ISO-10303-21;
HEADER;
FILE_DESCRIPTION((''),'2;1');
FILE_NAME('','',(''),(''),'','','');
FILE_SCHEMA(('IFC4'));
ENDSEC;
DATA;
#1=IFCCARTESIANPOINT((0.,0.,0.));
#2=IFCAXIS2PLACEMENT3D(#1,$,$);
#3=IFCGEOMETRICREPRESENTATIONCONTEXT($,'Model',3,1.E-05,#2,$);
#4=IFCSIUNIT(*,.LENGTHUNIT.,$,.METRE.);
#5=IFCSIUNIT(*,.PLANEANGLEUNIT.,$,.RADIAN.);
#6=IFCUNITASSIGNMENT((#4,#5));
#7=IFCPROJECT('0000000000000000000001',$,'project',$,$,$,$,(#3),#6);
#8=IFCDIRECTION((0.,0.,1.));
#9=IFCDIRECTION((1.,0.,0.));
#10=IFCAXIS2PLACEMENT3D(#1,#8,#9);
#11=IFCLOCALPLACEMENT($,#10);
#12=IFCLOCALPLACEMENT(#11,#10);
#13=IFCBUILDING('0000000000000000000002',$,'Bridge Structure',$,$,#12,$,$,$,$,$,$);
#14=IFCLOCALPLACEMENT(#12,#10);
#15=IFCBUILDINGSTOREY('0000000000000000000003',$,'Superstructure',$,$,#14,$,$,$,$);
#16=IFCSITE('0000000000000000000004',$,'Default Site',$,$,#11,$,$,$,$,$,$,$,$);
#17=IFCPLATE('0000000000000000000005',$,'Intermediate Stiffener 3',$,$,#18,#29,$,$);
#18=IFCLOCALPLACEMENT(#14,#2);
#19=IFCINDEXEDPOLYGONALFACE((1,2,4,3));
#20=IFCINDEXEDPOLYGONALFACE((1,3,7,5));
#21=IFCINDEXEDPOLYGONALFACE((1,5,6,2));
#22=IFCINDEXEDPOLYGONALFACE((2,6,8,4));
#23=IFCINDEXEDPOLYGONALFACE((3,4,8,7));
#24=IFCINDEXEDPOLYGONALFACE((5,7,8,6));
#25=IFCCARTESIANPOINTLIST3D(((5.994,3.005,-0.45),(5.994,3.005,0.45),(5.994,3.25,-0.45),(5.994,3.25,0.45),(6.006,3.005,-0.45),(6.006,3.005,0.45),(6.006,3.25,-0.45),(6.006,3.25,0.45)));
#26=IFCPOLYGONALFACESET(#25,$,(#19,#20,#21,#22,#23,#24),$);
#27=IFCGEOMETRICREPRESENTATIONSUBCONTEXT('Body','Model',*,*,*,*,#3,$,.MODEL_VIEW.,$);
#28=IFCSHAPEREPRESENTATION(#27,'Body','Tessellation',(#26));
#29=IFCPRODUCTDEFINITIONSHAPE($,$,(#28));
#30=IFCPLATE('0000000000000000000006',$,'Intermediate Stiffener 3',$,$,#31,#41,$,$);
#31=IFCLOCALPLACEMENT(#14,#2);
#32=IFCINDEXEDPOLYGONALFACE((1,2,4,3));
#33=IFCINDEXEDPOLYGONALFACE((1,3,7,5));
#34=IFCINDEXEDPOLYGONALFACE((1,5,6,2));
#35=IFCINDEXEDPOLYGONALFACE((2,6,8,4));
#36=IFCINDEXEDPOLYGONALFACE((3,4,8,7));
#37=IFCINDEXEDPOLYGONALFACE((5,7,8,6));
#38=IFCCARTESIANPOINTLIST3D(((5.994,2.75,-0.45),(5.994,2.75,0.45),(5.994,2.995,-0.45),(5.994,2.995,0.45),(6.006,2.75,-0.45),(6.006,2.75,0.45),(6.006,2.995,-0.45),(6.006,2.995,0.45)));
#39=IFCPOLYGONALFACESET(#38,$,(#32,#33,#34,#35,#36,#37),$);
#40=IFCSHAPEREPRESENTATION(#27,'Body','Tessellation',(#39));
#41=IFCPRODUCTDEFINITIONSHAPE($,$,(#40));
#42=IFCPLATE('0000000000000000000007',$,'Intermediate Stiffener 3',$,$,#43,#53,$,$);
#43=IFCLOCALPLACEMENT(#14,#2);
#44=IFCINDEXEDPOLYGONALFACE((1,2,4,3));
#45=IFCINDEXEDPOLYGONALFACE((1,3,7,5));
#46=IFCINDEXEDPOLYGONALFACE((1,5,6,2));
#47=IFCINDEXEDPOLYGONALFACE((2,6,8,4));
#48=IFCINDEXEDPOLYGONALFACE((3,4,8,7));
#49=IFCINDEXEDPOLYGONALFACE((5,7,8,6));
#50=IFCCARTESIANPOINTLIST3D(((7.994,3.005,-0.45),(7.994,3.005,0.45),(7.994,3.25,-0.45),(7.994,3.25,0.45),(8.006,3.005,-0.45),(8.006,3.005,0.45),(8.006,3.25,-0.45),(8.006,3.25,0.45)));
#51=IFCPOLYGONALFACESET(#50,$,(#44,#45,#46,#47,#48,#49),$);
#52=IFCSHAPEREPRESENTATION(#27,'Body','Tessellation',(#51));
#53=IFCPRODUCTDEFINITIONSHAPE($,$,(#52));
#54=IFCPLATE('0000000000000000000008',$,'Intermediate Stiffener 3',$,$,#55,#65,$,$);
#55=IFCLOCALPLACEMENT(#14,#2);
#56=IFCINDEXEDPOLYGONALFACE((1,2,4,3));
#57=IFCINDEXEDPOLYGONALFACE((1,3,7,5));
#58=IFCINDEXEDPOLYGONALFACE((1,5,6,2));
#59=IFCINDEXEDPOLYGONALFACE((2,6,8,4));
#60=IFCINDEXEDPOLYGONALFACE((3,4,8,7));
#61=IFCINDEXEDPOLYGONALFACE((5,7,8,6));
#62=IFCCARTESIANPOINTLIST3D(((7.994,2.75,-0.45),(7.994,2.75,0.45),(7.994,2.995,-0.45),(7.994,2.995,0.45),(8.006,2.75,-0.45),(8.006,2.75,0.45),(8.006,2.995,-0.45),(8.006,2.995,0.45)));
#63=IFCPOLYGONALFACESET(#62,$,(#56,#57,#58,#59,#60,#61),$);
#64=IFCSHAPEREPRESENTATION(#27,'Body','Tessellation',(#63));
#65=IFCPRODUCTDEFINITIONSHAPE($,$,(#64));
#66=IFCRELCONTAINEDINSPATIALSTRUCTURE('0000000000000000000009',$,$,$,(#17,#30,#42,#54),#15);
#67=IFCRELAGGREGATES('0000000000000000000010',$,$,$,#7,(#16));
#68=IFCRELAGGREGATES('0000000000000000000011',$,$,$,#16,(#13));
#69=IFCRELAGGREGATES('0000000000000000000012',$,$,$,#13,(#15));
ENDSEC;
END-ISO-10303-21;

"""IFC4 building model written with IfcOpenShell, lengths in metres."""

from ifc_helpers import new_model, si_unit, frame, origin, origin_with_axes, origin_2d_with_axis, place, context, subcontext, project, spatial, rectangle, extrude, element, save


model = new_model("IFC4")

# Units and contexts
model_context = context("Model", 3, precision=1e-05, world=origin())
body_context = subcontext(model_context, "Body", "Model", "MODEL_VIEW")
ifc_project = project(units=[si_unit("LENGTHUNIT", "METRE"), si_unit("PLANEANGLEUNIT", "RADIAN")], contexts=[model_context])

# Site, building, storey
site_placement = place(None, origin_with_axes())
site = spatial("IfcSite", under=ifc_project, at=site_placement, Name="Default Site")
building_placement = place(site_placement, origin_with_axes())
building = spatial("IfcBuilding", under=site, at=building_placement, Name="Bridge Structure")
storey_placement = place(building_placement, origin_with_axes())
storey = spatial("IfcBuildingStorey", under=building, at=storey_placement, Name="Superstructure")

# Plates
for number, where, z_axis, x_axis, name in (
    (1, (6.0, 3.1275, -0.45), (0.0, 0.0, 1.0), (1.0, 0.0, 0.0), "Intermediate Stiffener 3"),
    (2, (6.0, 2.8725, -0.45), (0.0, 0.0, 1.0), (1.0, 0.0, 0.0), "Intermediate Stiffener 3"),
    (3, (8.0, 3.1275, -0.45), (0.0, 0.0, 1.0), (1.0, 0.0, 0.0), "Intermediate Stiffener 3"),
    (4, (8.0, 2.8725, -0.45), (0.0, 0.0, 1.0), (1.0, 0.0, 0.0), "Intermediate Stiffener 3"),
):
    element("IfcPlate", number, at=place(storey_placement, frame(where, z_axis=z_axis, x_axis=x_axis)), inside=storey, Name=name, context=body_context, shape_type="SweptSolid", body=[
        extrude(rectangle(XDim=0.012, YDim=0.245, at=origin_2d_with_axis()), origin_with_axes(), (0.0, 0.0, 1.0), 0.9),
    ])

save(model, "model.ifc")
